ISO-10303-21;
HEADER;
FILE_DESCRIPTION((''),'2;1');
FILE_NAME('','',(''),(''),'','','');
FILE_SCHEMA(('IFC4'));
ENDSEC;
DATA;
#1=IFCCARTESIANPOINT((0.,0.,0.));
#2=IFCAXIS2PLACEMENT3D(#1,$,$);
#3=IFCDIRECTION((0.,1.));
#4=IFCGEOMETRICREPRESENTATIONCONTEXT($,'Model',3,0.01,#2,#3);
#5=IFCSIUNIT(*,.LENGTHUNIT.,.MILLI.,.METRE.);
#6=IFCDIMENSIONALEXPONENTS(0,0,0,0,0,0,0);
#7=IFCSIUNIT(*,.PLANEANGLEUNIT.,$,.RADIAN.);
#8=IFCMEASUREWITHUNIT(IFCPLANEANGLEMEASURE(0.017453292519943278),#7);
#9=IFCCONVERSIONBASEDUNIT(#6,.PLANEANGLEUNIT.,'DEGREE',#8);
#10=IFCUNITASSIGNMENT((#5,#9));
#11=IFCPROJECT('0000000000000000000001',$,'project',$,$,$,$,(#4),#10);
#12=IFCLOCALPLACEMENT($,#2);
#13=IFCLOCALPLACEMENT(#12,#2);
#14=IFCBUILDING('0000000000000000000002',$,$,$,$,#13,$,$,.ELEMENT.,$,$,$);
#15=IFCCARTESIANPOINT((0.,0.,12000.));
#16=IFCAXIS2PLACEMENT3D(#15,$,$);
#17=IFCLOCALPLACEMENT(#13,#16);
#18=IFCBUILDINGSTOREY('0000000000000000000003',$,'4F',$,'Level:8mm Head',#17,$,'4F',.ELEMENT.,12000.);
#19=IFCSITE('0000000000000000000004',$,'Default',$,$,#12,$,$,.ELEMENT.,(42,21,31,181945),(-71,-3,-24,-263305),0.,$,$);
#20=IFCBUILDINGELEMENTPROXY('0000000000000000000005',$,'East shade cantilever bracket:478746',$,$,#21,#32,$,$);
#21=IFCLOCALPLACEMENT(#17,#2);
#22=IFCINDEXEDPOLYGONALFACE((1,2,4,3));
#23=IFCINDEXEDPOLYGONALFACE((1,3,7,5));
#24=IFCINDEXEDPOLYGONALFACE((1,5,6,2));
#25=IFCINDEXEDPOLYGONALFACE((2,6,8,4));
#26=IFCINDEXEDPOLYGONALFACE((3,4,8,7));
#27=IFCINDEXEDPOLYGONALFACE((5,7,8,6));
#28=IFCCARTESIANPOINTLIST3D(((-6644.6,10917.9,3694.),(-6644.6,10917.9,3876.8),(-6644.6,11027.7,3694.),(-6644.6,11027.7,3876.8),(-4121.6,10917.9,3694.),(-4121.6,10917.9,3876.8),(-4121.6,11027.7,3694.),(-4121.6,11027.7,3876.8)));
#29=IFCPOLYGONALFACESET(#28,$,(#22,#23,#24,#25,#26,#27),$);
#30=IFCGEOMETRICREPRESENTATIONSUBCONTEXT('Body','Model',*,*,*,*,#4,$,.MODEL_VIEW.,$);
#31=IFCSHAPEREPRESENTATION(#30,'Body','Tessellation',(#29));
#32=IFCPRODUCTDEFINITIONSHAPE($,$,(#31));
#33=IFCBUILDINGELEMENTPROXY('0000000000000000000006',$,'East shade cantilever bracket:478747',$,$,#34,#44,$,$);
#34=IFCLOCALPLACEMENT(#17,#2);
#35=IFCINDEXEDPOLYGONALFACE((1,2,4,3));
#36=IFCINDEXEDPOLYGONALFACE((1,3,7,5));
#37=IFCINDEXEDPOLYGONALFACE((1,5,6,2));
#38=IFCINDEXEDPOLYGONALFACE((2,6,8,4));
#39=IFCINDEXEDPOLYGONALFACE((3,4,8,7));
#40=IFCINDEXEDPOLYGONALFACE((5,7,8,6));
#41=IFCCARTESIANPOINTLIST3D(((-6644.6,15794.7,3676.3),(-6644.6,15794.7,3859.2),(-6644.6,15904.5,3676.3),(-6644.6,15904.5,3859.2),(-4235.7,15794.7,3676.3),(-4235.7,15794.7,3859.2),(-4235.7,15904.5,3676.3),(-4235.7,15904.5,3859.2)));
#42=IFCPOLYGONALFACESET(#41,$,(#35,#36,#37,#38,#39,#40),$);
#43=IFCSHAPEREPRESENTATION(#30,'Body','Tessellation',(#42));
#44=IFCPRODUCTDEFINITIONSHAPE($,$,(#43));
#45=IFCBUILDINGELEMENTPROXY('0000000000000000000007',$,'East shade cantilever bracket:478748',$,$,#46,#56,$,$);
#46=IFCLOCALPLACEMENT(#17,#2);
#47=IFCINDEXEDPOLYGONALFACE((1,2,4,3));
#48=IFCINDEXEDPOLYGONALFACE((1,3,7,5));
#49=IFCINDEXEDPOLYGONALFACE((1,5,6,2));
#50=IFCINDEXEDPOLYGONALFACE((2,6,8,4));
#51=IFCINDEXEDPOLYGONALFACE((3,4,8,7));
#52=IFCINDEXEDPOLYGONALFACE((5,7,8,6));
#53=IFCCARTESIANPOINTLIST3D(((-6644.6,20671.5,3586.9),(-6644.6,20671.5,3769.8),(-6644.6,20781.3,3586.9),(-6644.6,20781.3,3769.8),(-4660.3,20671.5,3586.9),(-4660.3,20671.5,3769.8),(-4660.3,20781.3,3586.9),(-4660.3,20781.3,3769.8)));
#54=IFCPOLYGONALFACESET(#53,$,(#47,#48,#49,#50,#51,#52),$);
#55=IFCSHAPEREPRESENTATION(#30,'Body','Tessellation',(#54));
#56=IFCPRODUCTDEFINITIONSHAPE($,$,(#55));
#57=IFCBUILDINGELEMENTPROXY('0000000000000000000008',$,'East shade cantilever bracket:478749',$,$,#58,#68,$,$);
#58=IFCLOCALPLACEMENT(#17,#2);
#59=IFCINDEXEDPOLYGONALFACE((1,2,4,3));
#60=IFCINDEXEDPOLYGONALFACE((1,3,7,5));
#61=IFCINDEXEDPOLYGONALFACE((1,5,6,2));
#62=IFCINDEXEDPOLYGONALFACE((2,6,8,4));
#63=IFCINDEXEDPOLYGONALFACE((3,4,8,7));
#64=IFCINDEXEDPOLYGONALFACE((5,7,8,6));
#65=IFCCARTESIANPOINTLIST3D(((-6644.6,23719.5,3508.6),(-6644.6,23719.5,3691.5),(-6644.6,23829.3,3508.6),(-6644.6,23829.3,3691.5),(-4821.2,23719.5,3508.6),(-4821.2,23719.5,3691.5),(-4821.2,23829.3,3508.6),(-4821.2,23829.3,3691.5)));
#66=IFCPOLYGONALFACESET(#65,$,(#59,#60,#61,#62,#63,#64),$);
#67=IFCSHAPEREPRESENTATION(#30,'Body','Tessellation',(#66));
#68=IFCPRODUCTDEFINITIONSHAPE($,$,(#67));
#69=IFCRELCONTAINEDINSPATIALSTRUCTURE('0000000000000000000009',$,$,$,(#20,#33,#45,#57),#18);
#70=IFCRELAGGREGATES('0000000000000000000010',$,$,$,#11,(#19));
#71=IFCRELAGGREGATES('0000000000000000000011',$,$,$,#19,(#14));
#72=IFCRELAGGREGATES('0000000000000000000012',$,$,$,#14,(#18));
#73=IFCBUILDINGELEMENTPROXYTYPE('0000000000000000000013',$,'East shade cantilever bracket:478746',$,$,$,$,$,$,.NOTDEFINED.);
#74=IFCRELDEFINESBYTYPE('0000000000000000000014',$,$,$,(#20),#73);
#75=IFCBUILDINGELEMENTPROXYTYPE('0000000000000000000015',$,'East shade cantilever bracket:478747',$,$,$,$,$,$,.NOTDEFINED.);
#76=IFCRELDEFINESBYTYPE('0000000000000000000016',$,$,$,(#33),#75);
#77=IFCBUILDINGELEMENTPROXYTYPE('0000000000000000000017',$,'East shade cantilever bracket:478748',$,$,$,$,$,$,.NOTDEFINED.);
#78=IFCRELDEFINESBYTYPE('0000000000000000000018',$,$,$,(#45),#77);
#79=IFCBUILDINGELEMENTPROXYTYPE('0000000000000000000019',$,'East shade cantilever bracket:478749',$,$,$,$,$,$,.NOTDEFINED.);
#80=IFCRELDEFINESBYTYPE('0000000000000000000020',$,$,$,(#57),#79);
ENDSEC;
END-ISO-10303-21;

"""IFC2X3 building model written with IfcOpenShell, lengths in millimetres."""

from ifc_helpers import new_model, entity, si_unit, converted_unit, direction, frame, frame_2d, origin, origin_2d_with_axis, place, context, subcontext, project, spatial, rectangle, extrude, type_object, element, save


model = new_model("IFC2X3")

# Units and contexts
model_context = context("Model", 3, precision=0.01, world=origin(), true_north=direction((0.0, 1.0)))
body_context = subcontext(model_context, "Body", "Model", "MODEL_VIEW")
ifc_project = project(units=[si_unit("LENGTHUNIT", "METRE", prefix="MILLI"), converted_unit("PLANEANGLEUNIT", "DEGREE", entity("IfcPlaneAngleMeasure", 0.017453292519943278), si_unit("PLANEANGLEUNIT", "RADIAN"), dimensions=[0, 0, 0, 0, 0, 0, 0])], contexts=[model_context])

# Site, building, storey
site_placement = place(None, origin())
site = spatial("IfcSite", under=ifc_project, at=site_placement, Name="Default", CompositionType="ELEMENT", RefLatitude=(42, 21, 31, 181945), RefLongitude=(-71, -3, -24, -263305), RefElevation=0.0)
building_placement = place(site_placement, origin())
building = spatial("IfcBuilding", under=site, at=building_placement, CompositionType="ELEMENT")
storey_placement = place(building_placement, frame((0.0, 0.0, 12000.0)))
storey = spatial("IfcBuildingStorey", under=building, at=storey_placement, Name="4F", ObjectType="Level:8mm Head", LongName="4F", CompositionType="ELEMENT", Elevation=12000.0)

# Building element proxies
building_element_proxy_type_1 = type_object("IfcBuildingElementProxyType", Name="East shade cantilever bracket:478746", PredefinedType="NOTDEFINED")
proxy_1_placement = place(storey_placement, origin())
element("IfcBuildingElementProxy", 1, at=proxy_1_placement, inside=storey, type_object=building_element_proxy_type_1, Name="East shade cantilever bracket:478746", context=body_context, shape_type="SweptSolid", body=[
    extrude(rectangle(XDim=2523.0, YDim=109.7, at=origin_2d_with_axis()), frame((-5383.1, 10972.8, 3694.0)), (0.0, 0.0, 1.0), 182.9),
])
building_element_proxy_type_2 = type_object("IfcBuildingElementProxyType", Name="East shade cantilever bracket:478747", PredefinedType="NOTDEFINED")
proxy_2_placement = place(storey_placement, origin())
element("IfcBuildingElementProxy", 2, at=proxy_2_placement, inside=storey, type_object=building_element_proxy_type_2, Name="East shade cantilever bracket:478747", context=body_context, shape_type="SweptSolid", body=[
    extrude(rectangle(XDim=2408.9, YDim=109.7, at=frame_2d((0.0, 0.0), x_axis=(1.0, 0.0))), frame((-5440.2, 15849.6, 3676.3)), (0.0, 0.0, 1.0), 182.9),
])
building_element_proxy_type_3 = type_object("IfcBuildingElementProxyType", Name="East shade cantilever bracket:478748", PredefinedType="NOTDEFINED")
proxy_3_placement = place(storey_placement, origin())
element("IfcBuildingElementProxy", 3, at=proxy_3_placement, inside=storey, type_object=building_element_proxy_type_3, Name="East shade cantilever bracket:478748", context=body_context, shape_type="SweptSolid", body=[
    extrude(rectangle(XDim=1984.3, YDim=109.7, at=origin_2d_with_axis()), frame((-5652.5, 20726.4, 3586.9)), (0.0, 0.0, 1.0), 182.9),
])
building_element_proxy_type_4 = type_object("IfcBuildingElementProxyType", Name="East shade cantilever bracket:478749", PredefinedType="NOTDEFINED")
proxy_4_placement = place(storey_placement, origin())
element("IfcBuildingElementProxy", 4, at=proxy_4_placement, inside=storey, type_object=building_element_proxy_type_4, Name="East shade cantilever bracket:478749", context=body_context, shape_type="SweptSolid", body=[
    extrude(rectangle(XDim=1823.4, YDim=109.7, at=origin_2d_with_axis()), frame((-5732.9, 23774.4, 3508.6)), (0.0, 0.0, 1.0), 182.9),
])

save(model, "model.ifc")
